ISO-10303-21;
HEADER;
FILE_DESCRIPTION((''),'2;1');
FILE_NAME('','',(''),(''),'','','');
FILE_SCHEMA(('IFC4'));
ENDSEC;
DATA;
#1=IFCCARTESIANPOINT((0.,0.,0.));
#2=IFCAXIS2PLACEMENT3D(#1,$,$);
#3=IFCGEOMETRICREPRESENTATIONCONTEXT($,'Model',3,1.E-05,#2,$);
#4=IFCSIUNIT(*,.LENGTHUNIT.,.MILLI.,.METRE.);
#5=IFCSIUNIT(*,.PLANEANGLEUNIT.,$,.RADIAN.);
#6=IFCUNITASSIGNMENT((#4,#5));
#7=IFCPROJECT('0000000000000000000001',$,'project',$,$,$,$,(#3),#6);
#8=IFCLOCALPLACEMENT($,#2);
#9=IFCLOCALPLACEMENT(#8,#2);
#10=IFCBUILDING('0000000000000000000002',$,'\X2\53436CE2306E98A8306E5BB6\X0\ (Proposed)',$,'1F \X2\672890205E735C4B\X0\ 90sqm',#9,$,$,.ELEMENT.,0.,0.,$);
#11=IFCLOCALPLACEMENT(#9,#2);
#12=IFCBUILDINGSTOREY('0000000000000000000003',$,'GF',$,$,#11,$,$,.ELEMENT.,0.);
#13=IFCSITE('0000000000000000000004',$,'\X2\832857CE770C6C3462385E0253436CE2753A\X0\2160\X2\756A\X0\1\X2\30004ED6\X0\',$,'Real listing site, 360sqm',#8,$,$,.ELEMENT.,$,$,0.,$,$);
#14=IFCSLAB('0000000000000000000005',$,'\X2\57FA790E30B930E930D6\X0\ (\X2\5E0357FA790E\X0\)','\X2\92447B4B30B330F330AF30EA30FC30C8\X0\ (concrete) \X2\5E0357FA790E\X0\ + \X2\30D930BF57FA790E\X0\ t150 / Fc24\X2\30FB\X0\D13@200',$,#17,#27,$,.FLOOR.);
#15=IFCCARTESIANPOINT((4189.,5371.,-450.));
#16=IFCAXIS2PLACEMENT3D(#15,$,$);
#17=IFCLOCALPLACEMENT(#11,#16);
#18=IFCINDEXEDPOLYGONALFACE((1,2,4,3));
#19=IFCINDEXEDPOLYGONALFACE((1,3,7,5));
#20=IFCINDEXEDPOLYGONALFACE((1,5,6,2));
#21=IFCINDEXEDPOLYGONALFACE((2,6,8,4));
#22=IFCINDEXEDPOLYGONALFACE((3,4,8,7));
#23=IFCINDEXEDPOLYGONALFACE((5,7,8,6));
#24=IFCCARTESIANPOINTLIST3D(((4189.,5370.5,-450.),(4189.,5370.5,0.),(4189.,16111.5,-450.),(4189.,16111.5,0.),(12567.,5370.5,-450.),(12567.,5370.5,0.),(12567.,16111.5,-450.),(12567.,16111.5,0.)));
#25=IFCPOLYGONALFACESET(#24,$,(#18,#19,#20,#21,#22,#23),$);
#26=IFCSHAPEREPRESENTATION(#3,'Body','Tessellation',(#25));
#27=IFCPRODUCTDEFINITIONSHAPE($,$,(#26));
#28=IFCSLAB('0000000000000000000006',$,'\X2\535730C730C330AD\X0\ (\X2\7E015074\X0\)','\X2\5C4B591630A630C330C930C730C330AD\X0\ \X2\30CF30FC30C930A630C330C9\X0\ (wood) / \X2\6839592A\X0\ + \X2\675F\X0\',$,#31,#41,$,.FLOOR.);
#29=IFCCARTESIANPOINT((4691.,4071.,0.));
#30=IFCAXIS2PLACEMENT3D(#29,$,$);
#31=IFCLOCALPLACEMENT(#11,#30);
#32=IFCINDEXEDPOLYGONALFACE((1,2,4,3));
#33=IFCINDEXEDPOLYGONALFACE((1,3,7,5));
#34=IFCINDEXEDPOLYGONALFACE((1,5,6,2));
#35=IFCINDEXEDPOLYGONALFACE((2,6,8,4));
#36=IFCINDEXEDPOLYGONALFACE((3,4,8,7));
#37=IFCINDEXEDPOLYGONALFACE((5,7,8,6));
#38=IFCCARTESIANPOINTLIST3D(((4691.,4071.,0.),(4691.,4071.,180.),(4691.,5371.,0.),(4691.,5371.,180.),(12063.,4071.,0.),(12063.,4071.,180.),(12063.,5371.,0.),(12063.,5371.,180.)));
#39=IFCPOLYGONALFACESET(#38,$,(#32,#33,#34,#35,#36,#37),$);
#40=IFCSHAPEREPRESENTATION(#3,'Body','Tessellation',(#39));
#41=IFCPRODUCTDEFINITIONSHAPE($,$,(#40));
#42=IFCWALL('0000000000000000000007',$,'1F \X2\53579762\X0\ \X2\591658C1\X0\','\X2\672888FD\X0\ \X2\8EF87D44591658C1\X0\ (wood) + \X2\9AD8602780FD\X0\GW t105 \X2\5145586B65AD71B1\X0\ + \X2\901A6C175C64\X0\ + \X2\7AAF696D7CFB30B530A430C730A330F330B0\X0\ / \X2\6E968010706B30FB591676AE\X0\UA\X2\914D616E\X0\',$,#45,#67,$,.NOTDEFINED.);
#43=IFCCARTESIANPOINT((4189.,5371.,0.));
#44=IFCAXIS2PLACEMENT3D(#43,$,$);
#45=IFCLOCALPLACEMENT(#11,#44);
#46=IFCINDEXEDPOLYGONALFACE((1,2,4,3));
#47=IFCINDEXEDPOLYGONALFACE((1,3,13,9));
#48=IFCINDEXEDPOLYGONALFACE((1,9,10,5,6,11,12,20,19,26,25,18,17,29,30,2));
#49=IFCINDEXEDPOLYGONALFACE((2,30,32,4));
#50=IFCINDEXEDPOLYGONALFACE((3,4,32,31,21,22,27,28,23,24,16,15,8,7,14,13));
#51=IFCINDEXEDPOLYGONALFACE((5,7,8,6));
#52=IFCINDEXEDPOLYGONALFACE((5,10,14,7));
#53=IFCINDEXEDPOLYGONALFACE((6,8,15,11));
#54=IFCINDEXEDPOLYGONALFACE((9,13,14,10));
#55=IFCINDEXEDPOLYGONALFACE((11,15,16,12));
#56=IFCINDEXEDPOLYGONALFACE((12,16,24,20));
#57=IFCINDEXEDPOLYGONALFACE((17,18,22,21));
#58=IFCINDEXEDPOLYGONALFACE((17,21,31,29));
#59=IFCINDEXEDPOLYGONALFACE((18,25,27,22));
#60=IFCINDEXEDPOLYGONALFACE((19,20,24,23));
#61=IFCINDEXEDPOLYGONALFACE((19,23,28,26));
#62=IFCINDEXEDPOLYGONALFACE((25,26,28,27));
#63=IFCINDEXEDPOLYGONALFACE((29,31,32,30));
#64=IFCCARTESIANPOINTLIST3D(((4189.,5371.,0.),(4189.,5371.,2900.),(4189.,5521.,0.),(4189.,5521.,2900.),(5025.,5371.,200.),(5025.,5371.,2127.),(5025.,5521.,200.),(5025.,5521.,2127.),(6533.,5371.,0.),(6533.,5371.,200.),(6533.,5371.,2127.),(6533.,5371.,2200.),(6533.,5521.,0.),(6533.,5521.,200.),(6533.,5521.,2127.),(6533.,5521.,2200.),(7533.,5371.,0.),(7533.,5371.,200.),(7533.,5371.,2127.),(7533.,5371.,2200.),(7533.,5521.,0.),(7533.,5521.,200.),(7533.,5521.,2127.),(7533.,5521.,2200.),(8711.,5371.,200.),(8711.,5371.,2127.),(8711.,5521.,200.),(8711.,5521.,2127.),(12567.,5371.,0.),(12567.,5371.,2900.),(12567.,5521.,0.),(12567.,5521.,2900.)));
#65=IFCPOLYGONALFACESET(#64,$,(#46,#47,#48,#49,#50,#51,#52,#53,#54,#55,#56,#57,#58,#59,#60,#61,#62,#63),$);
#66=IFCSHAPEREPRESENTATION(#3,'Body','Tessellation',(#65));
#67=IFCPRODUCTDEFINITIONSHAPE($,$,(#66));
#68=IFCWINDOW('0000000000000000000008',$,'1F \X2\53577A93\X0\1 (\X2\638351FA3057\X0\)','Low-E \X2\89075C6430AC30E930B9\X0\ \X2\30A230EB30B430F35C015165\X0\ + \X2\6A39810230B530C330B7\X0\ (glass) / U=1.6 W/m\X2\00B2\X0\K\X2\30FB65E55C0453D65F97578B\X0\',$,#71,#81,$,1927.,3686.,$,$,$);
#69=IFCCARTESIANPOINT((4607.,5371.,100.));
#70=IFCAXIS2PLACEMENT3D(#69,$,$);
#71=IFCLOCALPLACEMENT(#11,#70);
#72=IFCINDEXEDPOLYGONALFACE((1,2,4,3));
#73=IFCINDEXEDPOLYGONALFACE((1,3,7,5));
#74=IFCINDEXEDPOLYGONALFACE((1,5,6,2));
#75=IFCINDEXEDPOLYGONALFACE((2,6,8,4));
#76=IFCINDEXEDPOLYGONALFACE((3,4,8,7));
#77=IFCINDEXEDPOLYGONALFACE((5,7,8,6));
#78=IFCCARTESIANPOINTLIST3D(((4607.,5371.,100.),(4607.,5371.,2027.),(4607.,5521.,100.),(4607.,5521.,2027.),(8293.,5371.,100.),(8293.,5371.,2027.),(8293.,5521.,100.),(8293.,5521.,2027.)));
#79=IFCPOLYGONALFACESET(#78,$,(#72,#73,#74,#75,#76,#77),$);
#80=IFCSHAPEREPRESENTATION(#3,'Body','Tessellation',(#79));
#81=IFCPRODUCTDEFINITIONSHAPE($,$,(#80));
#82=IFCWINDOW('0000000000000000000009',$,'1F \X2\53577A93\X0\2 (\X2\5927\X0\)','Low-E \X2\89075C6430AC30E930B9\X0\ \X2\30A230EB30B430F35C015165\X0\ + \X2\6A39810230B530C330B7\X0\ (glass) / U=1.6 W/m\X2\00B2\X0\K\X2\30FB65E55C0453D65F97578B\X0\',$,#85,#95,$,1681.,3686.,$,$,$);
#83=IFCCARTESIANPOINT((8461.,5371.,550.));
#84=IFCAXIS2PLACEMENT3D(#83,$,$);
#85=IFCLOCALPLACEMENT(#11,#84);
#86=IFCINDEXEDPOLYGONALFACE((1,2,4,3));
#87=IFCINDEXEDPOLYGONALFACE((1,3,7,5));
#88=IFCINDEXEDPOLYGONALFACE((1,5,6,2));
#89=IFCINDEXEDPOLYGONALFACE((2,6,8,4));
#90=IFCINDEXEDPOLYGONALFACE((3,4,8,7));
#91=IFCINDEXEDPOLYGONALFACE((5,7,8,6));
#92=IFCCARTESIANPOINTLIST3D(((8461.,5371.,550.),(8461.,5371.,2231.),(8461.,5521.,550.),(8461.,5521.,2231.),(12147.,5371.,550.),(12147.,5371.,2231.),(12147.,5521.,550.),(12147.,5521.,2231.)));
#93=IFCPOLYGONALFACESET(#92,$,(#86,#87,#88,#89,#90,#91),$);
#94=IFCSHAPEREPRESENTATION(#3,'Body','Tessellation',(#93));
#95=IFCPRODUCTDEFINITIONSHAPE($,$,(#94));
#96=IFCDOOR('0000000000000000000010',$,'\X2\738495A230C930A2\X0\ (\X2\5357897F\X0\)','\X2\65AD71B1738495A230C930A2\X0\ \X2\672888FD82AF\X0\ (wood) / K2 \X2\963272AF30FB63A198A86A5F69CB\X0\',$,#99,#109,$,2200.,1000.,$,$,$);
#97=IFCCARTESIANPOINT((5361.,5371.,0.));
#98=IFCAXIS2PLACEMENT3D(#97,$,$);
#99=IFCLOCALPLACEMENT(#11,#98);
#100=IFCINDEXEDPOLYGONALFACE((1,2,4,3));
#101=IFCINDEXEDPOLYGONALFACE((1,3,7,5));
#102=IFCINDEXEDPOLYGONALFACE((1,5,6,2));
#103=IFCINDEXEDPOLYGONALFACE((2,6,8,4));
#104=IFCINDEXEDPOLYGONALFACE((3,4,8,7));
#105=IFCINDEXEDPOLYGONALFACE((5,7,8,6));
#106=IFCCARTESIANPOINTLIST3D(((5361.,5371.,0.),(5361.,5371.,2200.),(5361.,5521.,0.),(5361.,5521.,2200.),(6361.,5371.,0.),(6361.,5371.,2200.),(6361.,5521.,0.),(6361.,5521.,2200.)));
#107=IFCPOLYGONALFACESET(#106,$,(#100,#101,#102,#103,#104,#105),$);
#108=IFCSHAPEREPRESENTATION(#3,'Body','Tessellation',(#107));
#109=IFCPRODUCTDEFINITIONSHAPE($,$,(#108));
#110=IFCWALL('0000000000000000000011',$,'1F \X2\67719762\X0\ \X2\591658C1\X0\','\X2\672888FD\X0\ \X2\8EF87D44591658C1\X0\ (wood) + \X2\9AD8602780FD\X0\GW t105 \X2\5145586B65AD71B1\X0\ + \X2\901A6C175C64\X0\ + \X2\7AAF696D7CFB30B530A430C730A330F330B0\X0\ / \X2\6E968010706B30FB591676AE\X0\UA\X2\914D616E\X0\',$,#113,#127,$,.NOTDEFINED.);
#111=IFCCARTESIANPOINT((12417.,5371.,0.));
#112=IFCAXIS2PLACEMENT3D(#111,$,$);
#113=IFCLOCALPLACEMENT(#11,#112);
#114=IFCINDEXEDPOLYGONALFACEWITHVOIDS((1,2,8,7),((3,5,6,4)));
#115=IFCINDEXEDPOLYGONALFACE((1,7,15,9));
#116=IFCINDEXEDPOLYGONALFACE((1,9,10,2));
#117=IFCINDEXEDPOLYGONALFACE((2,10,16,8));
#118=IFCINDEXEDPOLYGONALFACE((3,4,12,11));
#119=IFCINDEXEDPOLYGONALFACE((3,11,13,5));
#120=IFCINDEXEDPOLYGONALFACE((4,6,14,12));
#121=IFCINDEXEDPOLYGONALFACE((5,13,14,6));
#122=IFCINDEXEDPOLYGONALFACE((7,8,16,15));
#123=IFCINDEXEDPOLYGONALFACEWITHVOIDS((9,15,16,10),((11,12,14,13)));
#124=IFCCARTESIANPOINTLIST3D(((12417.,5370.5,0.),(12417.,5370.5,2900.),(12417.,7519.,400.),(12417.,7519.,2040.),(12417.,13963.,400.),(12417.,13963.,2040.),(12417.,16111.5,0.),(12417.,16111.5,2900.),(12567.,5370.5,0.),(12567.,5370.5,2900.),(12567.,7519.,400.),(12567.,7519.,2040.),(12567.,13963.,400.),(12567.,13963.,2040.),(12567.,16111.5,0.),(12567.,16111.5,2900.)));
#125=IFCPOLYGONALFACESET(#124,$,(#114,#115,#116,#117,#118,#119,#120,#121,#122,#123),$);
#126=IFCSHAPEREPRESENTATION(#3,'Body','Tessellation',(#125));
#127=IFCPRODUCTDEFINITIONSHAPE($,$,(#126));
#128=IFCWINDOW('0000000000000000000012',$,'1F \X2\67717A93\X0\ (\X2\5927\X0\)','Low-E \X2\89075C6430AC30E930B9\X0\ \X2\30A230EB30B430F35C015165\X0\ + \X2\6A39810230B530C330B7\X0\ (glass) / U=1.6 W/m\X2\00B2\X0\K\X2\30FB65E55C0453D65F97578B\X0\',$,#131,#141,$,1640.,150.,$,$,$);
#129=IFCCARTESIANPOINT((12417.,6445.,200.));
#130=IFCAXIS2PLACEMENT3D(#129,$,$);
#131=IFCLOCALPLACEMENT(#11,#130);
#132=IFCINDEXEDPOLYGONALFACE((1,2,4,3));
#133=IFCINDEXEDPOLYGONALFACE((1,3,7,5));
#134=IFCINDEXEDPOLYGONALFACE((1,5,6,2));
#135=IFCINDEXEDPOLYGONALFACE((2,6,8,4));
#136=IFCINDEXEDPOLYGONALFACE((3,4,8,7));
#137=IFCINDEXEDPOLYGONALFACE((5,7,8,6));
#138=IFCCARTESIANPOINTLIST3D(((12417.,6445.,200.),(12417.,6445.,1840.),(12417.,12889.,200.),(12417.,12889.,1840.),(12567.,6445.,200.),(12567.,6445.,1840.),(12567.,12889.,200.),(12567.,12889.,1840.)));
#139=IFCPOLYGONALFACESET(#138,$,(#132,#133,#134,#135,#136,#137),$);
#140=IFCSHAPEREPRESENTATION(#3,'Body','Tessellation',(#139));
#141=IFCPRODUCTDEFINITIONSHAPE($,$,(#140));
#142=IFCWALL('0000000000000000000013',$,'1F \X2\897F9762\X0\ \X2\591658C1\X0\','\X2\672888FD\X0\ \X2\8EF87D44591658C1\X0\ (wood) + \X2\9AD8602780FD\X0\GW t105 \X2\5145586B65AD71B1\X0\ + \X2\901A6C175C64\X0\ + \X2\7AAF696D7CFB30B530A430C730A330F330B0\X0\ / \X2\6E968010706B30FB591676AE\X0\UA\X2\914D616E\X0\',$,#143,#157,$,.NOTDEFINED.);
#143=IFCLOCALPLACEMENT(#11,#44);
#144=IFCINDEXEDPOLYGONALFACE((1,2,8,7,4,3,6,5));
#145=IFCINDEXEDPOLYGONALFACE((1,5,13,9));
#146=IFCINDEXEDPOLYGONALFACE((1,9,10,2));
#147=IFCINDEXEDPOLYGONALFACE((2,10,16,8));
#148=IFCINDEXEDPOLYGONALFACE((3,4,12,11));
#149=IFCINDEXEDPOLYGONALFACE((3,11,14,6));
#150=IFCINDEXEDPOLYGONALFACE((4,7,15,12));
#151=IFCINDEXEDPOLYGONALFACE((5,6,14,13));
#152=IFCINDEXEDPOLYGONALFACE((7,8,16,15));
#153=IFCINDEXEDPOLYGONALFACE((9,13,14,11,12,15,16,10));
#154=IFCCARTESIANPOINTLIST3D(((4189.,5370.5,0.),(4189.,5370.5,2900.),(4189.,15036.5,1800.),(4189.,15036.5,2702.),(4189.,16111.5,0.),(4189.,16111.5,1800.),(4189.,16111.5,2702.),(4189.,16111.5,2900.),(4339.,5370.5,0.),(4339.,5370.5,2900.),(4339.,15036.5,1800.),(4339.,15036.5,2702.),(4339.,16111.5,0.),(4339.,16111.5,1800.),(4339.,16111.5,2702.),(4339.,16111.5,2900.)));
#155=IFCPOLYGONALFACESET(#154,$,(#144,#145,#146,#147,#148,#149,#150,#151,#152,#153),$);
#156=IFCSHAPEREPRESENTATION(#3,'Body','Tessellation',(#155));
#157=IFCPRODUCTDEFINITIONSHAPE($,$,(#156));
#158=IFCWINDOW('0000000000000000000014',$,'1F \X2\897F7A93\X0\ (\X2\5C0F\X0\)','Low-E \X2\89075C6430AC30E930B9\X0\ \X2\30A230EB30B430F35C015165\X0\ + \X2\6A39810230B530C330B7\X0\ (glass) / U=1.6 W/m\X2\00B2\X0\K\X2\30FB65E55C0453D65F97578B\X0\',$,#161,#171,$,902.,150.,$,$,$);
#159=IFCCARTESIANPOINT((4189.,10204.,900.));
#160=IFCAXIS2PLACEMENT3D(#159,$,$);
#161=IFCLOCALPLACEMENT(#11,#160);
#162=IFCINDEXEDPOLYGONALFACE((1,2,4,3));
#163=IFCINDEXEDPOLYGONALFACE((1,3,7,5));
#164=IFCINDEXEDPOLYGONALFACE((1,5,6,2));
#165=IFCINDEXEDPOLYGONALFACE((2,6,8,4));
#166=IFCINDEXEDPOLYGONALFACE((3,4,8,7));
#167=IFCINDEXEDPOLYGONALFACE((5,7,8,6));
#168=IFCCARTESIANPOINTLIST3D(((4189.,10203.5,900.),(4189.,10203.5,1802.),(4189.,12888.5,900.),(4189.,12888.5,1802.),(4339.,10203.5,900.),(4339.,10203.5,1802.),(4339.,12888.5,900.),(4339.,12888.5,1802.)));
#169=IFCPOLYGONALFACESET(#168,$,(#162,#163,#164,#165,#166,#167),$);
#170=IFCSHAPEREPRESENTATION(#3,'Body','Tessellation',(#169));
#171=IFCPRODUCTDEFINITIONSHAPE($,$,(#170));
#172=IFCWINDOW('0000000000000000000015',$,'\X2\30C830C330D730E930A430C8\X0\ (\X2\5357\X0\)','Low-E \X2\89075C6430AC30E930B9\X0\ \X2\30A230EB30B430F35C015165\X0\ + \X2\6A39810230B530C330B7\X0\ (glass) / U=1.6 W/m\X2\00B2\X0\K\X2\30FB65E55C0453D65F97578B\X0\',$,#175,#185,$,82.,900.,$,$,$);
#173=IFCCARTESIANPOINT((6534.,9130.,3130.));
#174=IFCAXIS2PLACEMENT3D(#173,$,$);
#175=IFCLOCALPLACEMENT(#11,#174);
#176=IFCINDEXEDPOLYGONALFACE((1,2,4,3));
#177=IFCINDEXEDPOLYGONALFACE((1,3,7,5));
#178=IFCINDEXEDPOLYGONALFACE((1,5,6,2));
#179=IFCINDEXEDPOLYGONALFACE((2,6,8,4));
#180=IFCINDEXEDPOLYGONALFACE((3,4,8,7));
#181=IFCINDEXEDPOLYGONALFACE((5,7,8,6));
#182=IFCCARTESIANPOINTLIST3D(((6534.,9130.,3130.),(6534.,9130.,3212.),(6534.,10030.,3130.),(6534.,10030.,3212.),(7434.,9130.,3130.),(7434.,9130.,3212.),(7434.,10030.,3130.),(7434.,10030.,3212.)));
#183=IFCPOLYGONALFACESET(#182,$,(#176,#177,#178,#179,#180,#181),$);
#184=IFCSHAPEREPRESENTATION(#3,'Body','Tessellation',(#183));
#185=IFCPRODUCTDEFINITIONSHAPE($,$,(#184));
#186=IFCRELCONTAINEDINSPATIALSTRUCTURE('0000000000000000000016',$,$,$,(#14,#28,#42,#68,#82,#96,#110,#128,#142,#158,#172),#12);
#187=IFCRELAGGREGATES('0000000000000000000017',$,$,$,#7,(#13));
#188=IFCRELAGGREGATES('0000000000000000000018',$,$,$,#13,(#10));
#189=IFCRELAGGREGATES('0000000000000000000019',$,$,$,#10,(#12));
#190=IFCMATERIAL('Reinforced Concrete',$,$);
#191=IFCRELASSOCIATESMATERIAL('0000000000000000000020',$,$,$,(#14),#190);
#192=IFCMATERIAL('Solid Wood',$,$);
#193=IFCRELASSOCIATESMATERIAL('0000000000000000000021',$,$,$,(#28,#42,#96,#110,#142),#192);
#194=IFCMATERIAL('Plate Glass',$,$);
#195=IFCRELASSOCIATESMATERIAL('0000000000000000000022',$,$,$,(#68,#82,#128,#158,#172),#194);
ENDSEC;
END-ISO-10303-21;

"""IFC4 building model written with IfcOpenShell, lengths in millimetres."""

from ifc_helpers import new_model, si_unit, frame, frame_2d, origin, place, context, project, spatial, rectangle, extrude, material, element, fill, save


model = new_model("IFC4")

# Units and contexts
model_context = context("Model", 3, precision=1e-05, world=origin())
ifc_project = project(units=[si_unit("LENGTHUNIT", "METRE", prefix="MILLI"), si_unit("PLANEANGLEUNIT", "RADIAN")], contexts=[model_context])

# Site, building, storey
site_placement = place(None, origin())
site = spatial("IfcSite", under=ifc_project, at=site_placement, Name="茨城県水戸市千波町2160番1　他", ObjectType="Real listing site, 360sqm", CompositionType="ELEMENT", RefElevation=0.0)
building_placement = place(site_placement, origin())
building = spatial("IfcBuilding", under=site, at=building_placement, Name="千波の風の家 (Proposed)", ObjectType="1F 木造平屋 90sqm", CompositionType="ELEMENT", ElevationOfRefHeight=0.0, ElevationOfTerrain=0.0)
storey_placement = place(building_placement, origin())
storey = spatial("IfcBuildingStorey", under=building, at=storey_placement, Name="GF", CompositionType="ELEMENT", Elevation=0.0)

# Slabs
ifc_material_1 = material(Name="Reinforced Concrete")
slab_1_placement = place(storey_placement, frame((4189.0, 5371.0, -450.0)))
element("IfcSlab", 1, at=slab_1_placement, inside=storey, material=ifc_material_1, Name="基礎スラブ (布基礎)", Description="鉄筋コンクリート (concrete) 布基礎 + ベタ基礎 t150 / Fc24・D13@200", PredefinedType="FLOOR", context=model_context, shape_type="SweptSolid", body=[
    extrude(rectangle(XDim=8378.0, YDim=10741.0, at=frame_2d((4189.0, 5370.0))), frame((4189.0, 5371.0, -450.0)), (0.0, 0.0, 1.0), 450.0),
])
ifc_material_2 = material(Name="Solid Wood")
slab_2_placement = place(storey_placement, frame((4691.0, 4071.0, 0.0)))
element("IfcSlab", 2, at=slab_2_placement, inside=storey, material=ifc_material_2, Name="南デッキ (縁側)", Description="屋外ウッドデッキ ハードウッド (wood) / 根太 + 束", PredefinedType="FLOOR", context=model_context, shape_type="SweptSolid", body=[
    extrude(rectangle(XDim=7372.0, YDim=1300.0, at=frame_2d((3686.0, 650.0))), frame((4691.0, 4071.0, 0.0)), (0.0, 0.0, 1.0), 180.0),
])

# Wall, openings, windows, door
wall_1_placement = place(storey_placement, frame((4189.0, 5371.0, 0.0)))
wall_1 = element("IfcWall", 3, at=wall_1_placement, inside=storey, material=ifc_material_2, Name="1F 南面 外壁", Description="木製 軸組外壁 (wood) + 高性能GW t105 充填断熱 + 通気層 + 窯業系サイディング / 準耐火・外皮UA配慮", PredefinedType="NOTDEFINED", context=model_context, shape_type="SweptSolid", body=[
    extrude(rectangle(XDim=8378.0, YDim=150.0, at=frame_2d((4189.0, 75.0))), frame((4189.0, 5371.0, 0.0)), (0.0, 0.0, 1.0), 2900.0),
])
opening_1_placement = place(storey_placement, frame((4607.0, 5371.0, 100.0)))
opening_1 = element("IfcOpeningElement", 4, at=opening_1_placement, cuts=wall_1, PredefinedType="NOTDEFINED", context=model_context, shape_type="SweptSolid", body=[
    extrude(rectangle(XDim=3686.0, YDim=150.0, at=frame_2d((1843.0, 75.0))), frame((4607.0, 5371.0, 100.0)), (0.0, 0.0, 1.0), 1927.0),
])
opening_2_placement = place(storey_placement, frame((8461.0, 5371.0, 550.0)))
opening_2 = element("IfcOpeningElement", 5, at=opening_2_placement, cuts=wall_1, PredefinedType="NOTDEFINED", context=model_context, shape_type="SweptSolid", body=[
    extrude(rectangle(XDim=3686.0, YDim=150.0, at=frame_2d((1843.0, 75.0))), frame((8461.0, 5371.0, 550.0)), (0.0, 0.0, 1.0), 1681.0),
])
opening_3_placement = place(storey_placement, frame((5361.0, 5371.0, 0.0)))
opening_3 = element("IfcOpeningElement", 6, at=opening_3_placement, cuts=wall_1, PredefinedType="NOTDEFINED", context=model_context, shape_type="SweptSolid", body=[
    extrude(rectangle(XDim=1000.0, YDim=150.0, at=frame_2d((500.0, 75.0))), frame((5361.0, 5371.0, 0.0)), (0.0, 0.0, 1.0), 2200.0),
])
ifc_material_3 = material(Name="Plate Glass")
window_1_placement = place(storey_placement, frame((4607.0, 5371.0, 100.0)))
window_1 = element("IfcWindow", 7, at=window_1_placement, inside=storey, material=ifc_material_3, Name="1F 南窓1 (掃出し)", Description="Low-E 複層ガラス アルゴン封入 + 樹脂サッシ (glass) / U=1.6 W/m²K・日射取得型", OverallHeight=1927.0, OverallWidth=3686.0, context=model_context, shape_type="SweptSolid", body=[
    extrude(rectangle(XDim=3686.0, YDim=150.0, at=frame_2d((1843.0, 75.0))), frame((4607.0, 5371.0, 100.0)), (0.0, 0.0, 1.0), 1927.0),
])
fill(opening_1, window_1)
window_2_placement = place(storey_placement, frame((8461.0, 5371.0, 550.0)))
window_2 = element("IfcWindow", 8, at=window_2_placement, inside=storey, material=ifc_material_3, Name="1F 南窓2 (大)", Description="Low-E 複層ガラス アルゴン封入 + 樹脂サッシ (glass) / U=1.6 W/m²K・日射取得型", OverallHeight=1681.0, OverallWidth=3686.0, context=model_context, shape_type="SweptSolid", body=[
    extrude(rectangle(XDim=3686.0, YDim=150.0, at=frame_2d((1843.0, 75.0))), frame((8461.0, 5371.0, 550.0)), (0.0, 0.0, 1.0), 1681.0),
])
fill(opening_2, window_2)
door_placement = place(storey_placement, frame((5361.0, 5371.0, 0.0)))
door = element("IfcDoor", 9, at=door_placement, inside=storey, material=ifc_material_2, Name="玄関ドア (南西)", Description="断熱玄関ドア 木製芯 (wood) / K2 防犯・採風機構", OverallHeight=2200.0, OverallWidth=1000.0, context=model_context, shape_type="SweptSolid", body=[
    extrude(rectangle(XDim=1000.0, YDim=150.0, at=frame_2d((500.0, 75.0))), frame((5361.0, 5371.0, 0.0)), (0.0, 0.0, 1.0), 2200.0),
])
fill(opening_3, door)

# Walls, openings, windows
wall_2_placement = place(storey_placement, frame((12417.0, 5371.0, 0.0)))
wall_2 = element("IfcWall", 10, at=wall_2_placement, inside=storey, material=ifc_material_2, Name="1F 東面 外壁", Description="木製 軸組外壁 (wood) + 高性能GW t105 充填断熱 + 通気層 + 窯業系サイディング / 準耐火・外皮UA配慮", PredefinedType="NOTDEFINED", context=model_context, shape_type="SweptSolid", body=[
    extrude(rectangle(XDim=150.0, YDim=10741.0, at=frame_2d((75.0, 5370.0))), frame((12417.0, 5371.0, 0.0)), (0.0, 0.0, 1.0), 2900.0),
])
opening_4_placement = place(storey_placement, frame((12417.0, 6445.0, 200.0)))
opening_4 = element("IfcOpeningElement", 11, at=opening_4_placement, cuts=wall_2, PredefinedType="NOTDEFINED", context=model_context, shape_type="SweptSolid", body=[
    extrude(rectangle(XDim=150.0, YDim=6444.0, at=frame_2d((75.0, 3222.0))), frame((12417.0, 6445.0, 200.0)), (0.0, 0.0, 1.0), 1640.0),
])
window_3_placement = place(storey_placement, frame((12417.0, 6445.0, 200.0)))
window_3 = element("IfcWindow", 12, at=window_3_placement, inside=storey, material=ifc_material_3, Name="1F 東窓 (大)", Description="Low-E 複層ガラス アルゴン封入 + 樹脂サッシ (glass) / U=1.6 W/m²K・日射取得型", OverallHeight=1640.0, OverallWidth=150.0, context=model_context, shape_type="SweptSolid", body=[
    extrude(rectangle(XDim=150.0, YDim=6444.0, at=frame_2d((75.0, 3222.0))), frame((12417.0, 6445.0, 200.0)), (0.0, 0.0, 1.0), 1640.0),
])
fill(opening_4, window_3)
wall_3_placement = place(storey_placement, frame((4189.0, 5371.0, 0.0)))
wall_3 = element("IfcWall", 13, at=wall_3_placement, inside=storey, material=ifc_material_2, Name="1F 西面 外壁", Description="木製 軸組外壁 (wood) + 高性能GW t105 充填断熱 + 通気層 + 窯業系サイディング / 準耐火・外皮UA配慮", PredefinedType="NOTDEFINED", context=model_context, shape_type="SweptSolid", body=[
    extrude(rectangle(XDim=150.0, YDim=10741.0, at=frame_2d((75.0, 5370.0))), frame((4189.0, 5371.0, 0.0)), (0.0, 0.0, 1.0), 2900.0),
])
opening_5_placement = place(storey_placement, frame((4189.0, 10204.0, 900.0)))
opening_5 = element("IfcOpeningElement", 14, at=opening_5_placement, cuts=wall_3, PredefinedType="NOTDEFINED", context=model_context, shape_type="SweptSolid", body=[
    extrude(rectangle(XDim=150.0, YDim=2685.0, at=frame_2d((75.0, 1342.0))), frame((4189.0, 10204.0, 900.0)), (0.0, 0.0, 1.0), 902.0),
])
window_4_placement = place(storey_placement, frame((4189.0, 10204.0, 900.0)))
window_4 = element("IfcWindow", 15, at=window_4_placement, inside=storey, material=ifc_material_3, Name="1F 西窓 (小)", Description="Low-E 複層ガラス アルゴン封入 + 樹脂サッシ (glass) / U=1.6 W/m²K・日射取得型", OverallHeight=902.0, OverallWidth=150.0, context=model_context, shape_type="SweptSolid", body=[
    extrude(rectangle(XDim=150.0, YDim=2685.0, at=frame_2d((75.0, 1342.0))), frame((4189.0, 10204.0, 900.0)), (0.0, 0.0, 1.0), 902.0),
])
fill(opening_5, window_4)

# Window
window_5_placement = place(storey_placement, frame((6534.0, 9130.0, 3130.0)))
element("IfcWindow", 16, at=window_5_placement, inside=storey, material=ifc_material_3, Name="トップライト (南)", Description="Low-E 複層ガラス アルゴン封入 + 樹脂サッシ (glass) / U=1.6 W/m²K・日射取得型", OverallHeight=82.0, OverallWidth=900.0, context=model_context, shape_type="SweptSolid", body=[
    extrude(rectangle(XDim=900.0, YDim=900.0, at=frame_2d((450.0, 450.0))), frame((6534.0, 9130.0, 3130.0)), (0.0, 0.0, 1.0), 82.0),
])

save(model, "model.ifc")
